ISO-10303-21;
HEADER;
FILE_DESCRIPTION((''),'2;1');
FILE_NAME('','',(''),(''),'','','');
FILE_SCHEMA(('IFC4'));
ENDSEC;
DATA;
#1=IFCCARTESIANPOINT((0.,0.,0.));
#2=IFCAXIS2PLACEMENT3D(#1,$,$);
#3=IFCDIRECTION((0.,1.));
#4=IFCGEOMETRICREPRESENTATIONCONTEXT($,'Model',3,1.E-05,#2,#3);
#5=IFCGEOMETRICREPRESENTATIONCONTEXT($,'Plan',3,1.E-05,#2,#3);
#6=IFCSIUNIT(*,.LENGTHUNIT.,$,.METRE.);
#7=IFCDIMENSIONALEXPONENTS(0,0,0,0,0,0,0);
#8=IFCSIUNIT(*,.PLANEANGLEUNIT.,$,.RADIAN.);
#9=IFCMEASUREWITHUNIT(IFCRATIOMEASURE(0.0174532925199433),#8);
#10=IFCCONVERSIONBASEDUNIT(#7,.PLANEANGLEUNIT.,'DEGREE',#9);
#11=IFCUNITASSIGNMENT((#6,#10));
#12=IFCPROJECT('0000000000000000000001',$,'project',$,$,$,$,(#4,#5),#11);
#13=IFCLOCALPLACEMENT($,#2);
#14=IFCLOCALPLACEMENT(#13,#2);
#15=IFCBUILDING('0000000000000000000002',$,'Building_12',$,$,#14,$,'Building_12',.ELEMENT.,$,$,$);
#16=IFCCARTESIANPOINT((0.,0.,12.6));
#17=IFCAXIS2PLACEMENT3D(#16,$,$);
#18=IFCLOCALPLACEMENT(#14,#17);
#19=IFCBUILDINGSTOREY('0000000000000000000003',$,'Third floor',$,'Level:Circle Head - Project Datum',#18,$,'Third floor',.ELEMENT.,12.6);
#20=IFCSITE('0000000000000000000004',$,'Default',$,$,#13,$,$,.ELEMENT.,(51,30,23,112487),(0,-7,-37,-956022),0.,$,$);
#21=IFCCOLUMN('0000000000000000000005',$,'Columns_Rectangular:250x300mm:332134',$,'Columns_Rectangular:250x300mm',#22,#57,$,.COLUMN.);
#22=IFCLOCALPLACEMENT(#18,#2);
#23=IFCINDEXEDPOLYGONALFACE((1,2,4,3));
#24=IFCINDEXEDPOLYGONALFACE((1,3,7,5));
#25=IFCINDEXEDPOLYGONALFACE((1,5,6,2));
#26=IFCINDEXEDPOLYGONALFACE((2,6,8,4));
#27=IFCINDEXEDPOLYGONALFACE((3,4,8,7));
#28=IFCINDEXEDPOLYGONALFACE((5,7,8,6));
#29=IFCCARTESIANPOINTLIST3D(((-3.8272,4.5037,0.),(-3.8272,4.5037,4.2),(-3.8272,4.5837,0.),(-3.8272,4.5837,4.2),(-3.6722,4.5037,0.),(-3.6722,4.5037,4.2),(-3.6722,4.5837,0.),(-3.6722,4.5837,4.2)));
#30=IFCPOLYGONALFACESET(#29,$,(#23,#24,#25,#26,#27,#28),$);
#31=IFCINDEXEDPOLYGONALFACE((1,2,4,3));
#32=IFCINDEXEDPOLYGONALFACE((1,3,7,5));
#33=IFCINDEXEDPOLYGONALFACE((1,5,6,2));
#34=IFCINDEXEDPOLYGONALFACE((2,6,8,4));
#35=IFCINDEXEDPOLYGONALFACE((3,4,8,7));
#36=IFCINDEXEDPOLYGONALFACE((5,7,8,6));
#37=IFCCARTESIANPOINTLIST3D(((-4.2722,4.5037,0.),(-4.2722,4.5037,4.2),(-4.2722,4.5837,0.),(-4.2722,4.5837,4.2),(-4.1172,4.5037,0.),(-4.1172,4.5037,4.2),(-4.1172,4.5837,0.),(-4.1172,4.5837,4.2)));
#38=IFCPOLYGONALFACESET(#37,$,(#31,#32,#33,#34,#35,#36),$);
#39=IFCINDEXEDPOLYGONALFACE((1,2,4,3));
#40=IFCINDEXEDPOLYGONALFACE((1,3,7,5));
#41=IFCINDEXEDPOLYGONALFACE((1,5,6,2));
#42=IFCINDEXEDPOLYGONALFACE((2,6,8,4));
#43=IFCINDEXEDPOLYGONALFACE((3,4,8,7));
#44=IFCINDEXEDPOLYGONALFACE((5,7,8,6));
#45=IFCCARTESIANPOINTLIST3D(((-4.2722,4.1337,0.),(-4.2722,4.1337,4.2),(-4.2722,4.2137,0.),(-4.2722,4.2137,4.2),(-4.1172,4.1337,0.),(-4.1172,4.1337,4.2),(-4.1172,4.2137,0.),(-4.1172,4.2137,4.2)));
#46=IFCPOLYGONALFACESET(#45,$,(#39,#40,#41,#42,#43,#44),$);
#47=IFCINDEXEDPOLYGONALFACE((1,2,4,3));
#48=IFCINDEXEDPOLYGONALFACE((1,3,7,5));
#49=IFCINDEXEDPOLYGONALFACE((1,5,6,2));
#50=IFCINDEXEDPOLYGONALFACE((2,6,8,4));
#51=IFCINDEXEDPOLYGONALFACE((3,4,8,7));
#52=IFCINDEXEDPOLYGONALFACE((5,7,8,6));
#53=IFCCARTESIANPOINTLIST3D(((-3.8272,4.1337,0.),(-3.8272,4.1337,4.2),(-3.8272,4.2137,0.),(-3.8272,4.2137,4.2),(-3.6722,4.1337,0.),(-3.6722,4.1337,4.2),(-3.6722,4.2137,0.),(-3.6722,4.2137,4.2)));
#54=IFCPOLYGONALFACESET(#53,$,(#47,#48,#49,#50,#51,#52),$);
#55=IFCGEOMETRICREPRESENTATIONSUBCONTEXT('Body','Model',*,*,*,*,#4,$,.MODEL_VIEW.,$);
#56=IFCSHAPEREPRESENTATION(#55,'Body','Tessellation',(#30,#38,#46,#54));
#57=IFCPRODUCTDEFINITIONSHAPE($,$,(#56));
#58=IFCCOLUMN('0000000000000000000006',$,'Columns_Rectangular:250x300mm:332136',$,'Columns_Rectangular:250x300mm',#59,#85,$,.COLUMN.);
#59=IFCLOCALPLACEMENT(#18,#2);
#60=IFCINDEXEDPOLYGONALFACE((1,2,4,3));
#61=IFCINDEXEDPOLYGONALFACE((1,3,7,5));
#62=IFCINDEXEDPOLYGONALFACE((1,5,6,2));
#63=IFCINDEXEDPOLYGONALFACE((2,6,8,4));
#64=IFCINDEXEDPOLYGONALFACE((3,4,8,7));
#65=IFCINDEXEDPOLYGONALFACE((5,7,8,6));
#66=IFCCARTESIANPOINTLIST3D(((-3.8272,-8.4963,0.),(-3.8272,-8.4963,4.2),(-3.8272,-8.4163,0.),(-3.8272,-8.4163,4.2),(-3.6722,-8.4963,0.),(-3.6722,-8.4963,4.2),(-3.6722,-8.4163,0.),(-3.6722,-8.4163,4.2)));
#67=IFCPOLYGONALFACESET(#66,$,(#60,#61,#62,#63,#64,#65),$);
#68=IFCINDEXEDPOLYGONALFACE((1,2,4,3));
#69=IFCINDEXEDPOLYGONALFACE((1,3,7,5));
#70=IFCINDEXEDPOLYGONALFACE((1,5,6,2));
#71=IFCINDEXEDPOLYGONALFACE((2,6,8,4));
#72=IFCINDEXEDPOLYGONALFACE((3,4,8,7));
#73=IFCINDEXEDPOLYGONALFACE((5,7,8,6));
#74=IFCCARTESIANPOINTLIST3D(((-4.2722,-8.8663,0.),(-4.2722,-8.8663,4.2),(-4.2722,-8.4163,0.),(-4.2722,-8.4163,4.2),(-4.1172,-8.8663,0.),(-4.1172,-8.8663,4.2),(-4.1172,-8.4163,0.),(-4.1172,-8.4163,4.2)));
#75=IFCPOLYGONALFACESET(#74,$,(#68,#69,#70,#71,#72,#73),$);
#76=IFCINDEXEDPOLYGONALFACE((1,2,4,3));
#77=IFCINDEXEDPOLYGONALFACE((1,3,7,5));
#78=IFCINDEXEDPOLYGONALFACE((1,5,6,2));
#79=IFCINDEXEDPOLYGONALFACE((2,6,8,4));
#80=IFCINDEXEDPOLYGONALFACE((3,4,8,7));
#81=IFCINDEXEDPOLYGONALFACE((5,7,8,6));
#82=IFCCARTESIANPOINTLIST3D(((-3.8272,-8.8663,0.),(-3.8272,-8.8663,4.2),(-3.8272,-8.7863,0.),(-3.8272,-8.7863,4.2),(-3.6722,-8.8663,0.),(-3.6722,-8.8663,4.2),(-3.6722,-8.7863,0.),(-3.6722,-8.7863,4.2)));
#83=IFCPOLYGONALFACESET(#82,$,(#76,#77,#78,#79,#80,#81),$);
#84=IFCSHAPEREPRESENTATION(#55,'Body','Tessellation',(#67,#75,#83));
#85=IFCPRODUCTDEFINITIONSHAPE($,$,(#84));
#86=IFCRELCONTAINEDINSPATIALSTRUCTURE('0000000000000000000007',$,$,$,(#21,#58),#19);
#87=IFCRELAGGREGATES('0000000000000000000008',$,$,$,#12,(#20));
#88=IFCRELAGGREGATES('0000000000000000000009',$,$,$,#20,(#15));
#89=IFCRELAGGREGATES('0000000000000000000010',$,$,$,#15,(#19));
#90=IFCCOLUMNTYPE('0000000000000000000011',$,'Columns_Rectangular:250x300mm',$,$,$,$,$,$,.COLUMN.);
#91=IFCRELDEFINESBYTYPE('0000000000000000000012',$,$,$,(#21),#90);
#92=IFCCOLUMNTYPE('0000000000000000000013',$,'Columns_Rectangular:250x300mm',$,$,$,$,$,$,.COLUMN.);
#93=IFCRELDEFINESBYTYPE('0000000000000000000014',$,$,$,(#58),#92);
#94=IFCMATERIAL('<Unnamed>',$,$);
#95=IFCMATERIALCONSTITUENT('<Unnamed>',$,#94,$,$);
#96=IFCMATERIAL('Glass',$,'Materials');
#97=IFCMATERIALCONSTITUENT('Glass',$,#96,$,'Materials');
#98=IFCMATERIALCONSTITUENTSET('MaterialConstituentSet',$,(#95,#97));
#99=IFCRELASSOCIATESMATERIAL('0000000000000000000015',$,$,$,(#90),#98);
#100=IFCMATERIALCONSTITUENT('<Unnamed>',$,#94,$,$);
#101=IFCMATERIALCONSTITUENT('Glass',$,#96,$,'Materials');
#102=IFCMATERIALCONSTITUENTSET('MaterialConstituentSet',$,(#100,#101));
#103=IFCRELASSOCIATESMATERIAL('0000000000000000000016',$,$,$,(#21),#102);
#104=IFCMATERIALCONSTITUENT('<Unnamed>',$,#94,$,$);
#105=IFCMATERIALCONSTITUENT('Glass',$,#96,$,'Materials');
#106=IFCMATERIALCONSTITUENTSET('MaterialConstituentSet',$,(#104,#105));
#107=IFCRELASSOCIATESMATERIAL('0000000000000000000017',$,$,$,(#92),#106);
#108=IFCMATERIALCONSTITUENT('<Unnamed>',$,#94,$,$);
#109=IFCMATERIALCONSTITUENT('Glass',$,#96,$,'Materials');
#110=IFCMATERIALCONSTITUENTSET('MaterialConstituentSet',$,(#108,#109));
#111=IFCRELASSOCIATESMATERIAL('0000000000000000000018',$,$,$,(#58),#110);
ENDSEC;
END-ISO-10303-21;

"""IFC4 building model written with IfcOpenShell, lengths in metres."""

from ifc_helpers import new_model, entity, si_unit, converted_unit, direction, frame, origin, place, context, subcontext, project, spatial, indexed_curve, outline, extrude, source, transform, mapped, material, constituent, constituent_set, type_object, type_shapes, element, save


model = new_model("IFC4")

# Units and contexts
model_context = context("Model", 3, precision=1e-05, world=origin(), true_north=direction((0.0, 1.0)))
plan_context = context("Plan", 3, precision=1e-05, world=origin(), true_north=direction((0.0, 1.0)))
body_context = subcontext(model_context, "Body", "Model", "MODEL_VIEW")
ifc_project = project(units=[si_unit("LENGTHUNIT", "METRE"), converted_unit("PLANEANGLEUNIT", "DEGREE", entity("IfcRatioMeasure", 0.0174532925199433), si_unit("PLANEANGLEUNIT", "RADIAN"), dimensions=[0, 0, 0, 0, 0, 0, 0])], contexts=[model_context, plan_context])

# Site, building, storey
site_placement = place(None, origin())
site = spatial("IfcSite", under=ifc_project, at=site_placement, Name="Default", CompositionType="ELEMENT", RefLatitude=(51, 30, 23, 112487), RefLongitude=(0, -7, -37, -956022), RefElevation=0.0)
building_placement = place(site_placement, origin())
building = spatial("IfcBuilding", under=site, at=building_placement, Name="Building_12", LongName="Building_12", CompositionType="ELEMENT")
storey_placement = place(building_placement, frame((0.0, 0.0, 12.6)))
storey = spatial("IfcBuildingStorey", under=building, at=storey_placement, Name="Third floor", ObjectType="Level:Circle Head - Project Datum", LongName="Third floor", CompositionType="ELEMENT", Elevation=12.6)

# Columns
ifc_material_1 = material(Name="<Unnamed>")
ifc_material_2 = material(Name="Glass", Category="Materials")
ifc_constituent_1 = constituent(ifc_material_1, Name="<Unnamed>")
ifc_constituent_2 = constituent(ifc_material_2, Name="Glass", Category="Materials")
ifc_constituent_set_1 = constituent_set(constituents=[ifc_constituent_1, ifc_constituent_2], Name="MaterialConstituentSet")
ifc_constituent_3 = constituent(ifc_material_1, Name="<Unnamed>")
ifc_constituent_4 = constituent(ifc_material_2, Name="Glass", Category="Materials")
ifc_constituent_set_2 = constituent_set(constituents=[ifc_constituent_3, ifc_constituent_4], Name="MaterialConstituentSet")
column_type_1 = type_object("IfcColumnType", Name="Columns_Rectangular:250x300mm", PredefinedType="COLUMN", material=ifc_constituent_set_2)
shared_shape_1 = source(origin(), body_context, "Body", "SweptSolid", [
    extrude(outline(indexed_curve([(-0.04, -0.0775), (0.04, -0.0775), (0.04, 0.0775), (-0.04, 0.0775), (-0.04, -0.0775)], self_intersect=False)), frame((-3.7497, 4.5437, 12.6), z_axis=(0.0, 0.0, 1.0), x_axis=(0.0, -1.0, 0.0)), (0.0, 0.0, 1.0), 4.2),
    extrude(outline(indexed_curve([(-0.04, -0.0775), (0.04, -0.0775), (0.04, 0.0775), (-0.04, 0.0775), (-0.04, -0.0775)], self_intersect=False)), frame((-4.1947, 4.5437, 12.6), z_axis=(0.0, 0.0, 1.0), x_axis=(0.0, -1.0, 0.0)), (0.0, 0.0, 1.0), 4.2),
    extrude(outline(indexed_curve([(-0.04, -0.0775), (0.04, -0.0775), (0.04, 0.0775), (-0.04, 0.0775), (-0.04, -0.0775)], self_intersect=False)), frame((-4.1947, 4.1737, 12.6), z_axis=(0.0, 0.0, 1.0), x_axis=(0.0, -1.0, 0.0)), (0.0, 0.0, 1.0), 4.2),
    extrude(outline(indexed_curve([(-0.04, -0.0775), (0.04, -0.0775), (0.04, 0.0775), (-0.04, 0.0775), (-0.04, -0.0775)], self_intersect=False)), frame((-3.7497, 4.1737, 12.6), z_axis=(0.0, 0.0, 1.0), x_axis=(0.0, -1.0, 0.0)), (0.0, 0.0, 1.0), 4.2),
])
type_shapes(column_type_1, [shared_shape_1])
column_1_placement = place(storey_placement, frame((0.0, 0.0, -12.6)))
element("IfcColumn", 1, at=column_1_placement, inside=storey, type_object=column_type_1, material=ifc_constituent_set_1, Name="Columns_Rectangular:250x300mm:332134", ObjectType="Columns_Rectangular:250x300mm", PredefinedType="COLUMN", context=body_context, shape_type="MappedRepresentation", body=[
    mapped(shared_shape_1, transform((0.0, 0.0, 0.0), scale=1.0)),
])
ifc_constituent_5 = constituent(ifc_material_1, Name="<Unnamed>")
ifc_constituent_6 = constituent(ifc_material_2, Name="Glass", Category="Materials")
ifc_constituent_set_3 = constituent_set(constituents=[ifc_constituent_5, ifc_constituent_6], Name="MaterialConstituentSet")
ifc_constituent_7 = constituent(ifc_material_1, Name="<Unnamed>")
ifc_constituent_8 = constituent(ifc_material_2, Name="Glass", Category="Materials")
ifc_constituent_set_4 = constituent_set(constituents=[ifc_constituent_7, ifc_constituent_8], Name="MaterialConstituentSet")
column_type_2 = type_object("IfcColumnType", Name="Columns_Rectangular:250x300mm", PredefinedType="COLUMN", material=ifc_constituent_set_4)
shared_shape_2 = source(origin(), body_context, "Body", "SweptSolid", [
    extrude(outline(indexed_curve([(-0.04, -0.0775), (0.04, -0.0775), (0.04, 0.0775), (-0.04, 0.0775), (-0.04, -0.0775)], self_intersect=False)), frame((-3.7497, -8.4563, 12.6), z_axis=(0.0, 0.0, 1.0), x_axis=(0.0, -1.0, 0.0)), (0.0, 0.0, 1.0), 4.2),
    extrude(outline(indexed_curve([(-0.225, -0.0775), (0.225, -0.0775), (0.225, 0.0775), (-0.225, 0.0775), (-0.225, -0.0775)], self_intersect=False)), frame((-4.1947, -8.6413, 12.6), z_axis=(0.0, 0.0, 1.0), x_axis=(0.0, -1.0, 0.0)), (0.0, 0.0, 1.0), 4.2),
    extrude(outline(indexed_curve([(-0.04, -0.0775), (0.04, -0.0775), (0.04, 0.0775), (-0.04, 0.0775), (-0.04, -0.0775)], self_intersect=False)), frame((-3.7497, -8.8263, 12.6), z_axis=(0.0, 0.0, 1.0), x_axis=(0.0, -1.0, 0.0)), (0.0, 0.0, 1.0), 4.2),
])
type_shapes(column_type_2, [shared_shape_2])
column_2_placement = place(storey_placement, frame((0.0, 0.0, -12.6)))
element("IfcColumn", 2, at=column_2_placement, inside=storey, type_object=column_type_2, material=ifc_constituent_set_3, Name="Columns_Rectangular:250x300mm:332136", ObjectType="Columns_Rectangular:250x300mm", PredefinedType="COLUMN", context=body_context, shape_type="MappedRepresentation", body=[
    mapped(shared_shape_2, transform((0.0, 0.0, 0.0), scale=1.0)),
])

save(model, "model.ifc")
